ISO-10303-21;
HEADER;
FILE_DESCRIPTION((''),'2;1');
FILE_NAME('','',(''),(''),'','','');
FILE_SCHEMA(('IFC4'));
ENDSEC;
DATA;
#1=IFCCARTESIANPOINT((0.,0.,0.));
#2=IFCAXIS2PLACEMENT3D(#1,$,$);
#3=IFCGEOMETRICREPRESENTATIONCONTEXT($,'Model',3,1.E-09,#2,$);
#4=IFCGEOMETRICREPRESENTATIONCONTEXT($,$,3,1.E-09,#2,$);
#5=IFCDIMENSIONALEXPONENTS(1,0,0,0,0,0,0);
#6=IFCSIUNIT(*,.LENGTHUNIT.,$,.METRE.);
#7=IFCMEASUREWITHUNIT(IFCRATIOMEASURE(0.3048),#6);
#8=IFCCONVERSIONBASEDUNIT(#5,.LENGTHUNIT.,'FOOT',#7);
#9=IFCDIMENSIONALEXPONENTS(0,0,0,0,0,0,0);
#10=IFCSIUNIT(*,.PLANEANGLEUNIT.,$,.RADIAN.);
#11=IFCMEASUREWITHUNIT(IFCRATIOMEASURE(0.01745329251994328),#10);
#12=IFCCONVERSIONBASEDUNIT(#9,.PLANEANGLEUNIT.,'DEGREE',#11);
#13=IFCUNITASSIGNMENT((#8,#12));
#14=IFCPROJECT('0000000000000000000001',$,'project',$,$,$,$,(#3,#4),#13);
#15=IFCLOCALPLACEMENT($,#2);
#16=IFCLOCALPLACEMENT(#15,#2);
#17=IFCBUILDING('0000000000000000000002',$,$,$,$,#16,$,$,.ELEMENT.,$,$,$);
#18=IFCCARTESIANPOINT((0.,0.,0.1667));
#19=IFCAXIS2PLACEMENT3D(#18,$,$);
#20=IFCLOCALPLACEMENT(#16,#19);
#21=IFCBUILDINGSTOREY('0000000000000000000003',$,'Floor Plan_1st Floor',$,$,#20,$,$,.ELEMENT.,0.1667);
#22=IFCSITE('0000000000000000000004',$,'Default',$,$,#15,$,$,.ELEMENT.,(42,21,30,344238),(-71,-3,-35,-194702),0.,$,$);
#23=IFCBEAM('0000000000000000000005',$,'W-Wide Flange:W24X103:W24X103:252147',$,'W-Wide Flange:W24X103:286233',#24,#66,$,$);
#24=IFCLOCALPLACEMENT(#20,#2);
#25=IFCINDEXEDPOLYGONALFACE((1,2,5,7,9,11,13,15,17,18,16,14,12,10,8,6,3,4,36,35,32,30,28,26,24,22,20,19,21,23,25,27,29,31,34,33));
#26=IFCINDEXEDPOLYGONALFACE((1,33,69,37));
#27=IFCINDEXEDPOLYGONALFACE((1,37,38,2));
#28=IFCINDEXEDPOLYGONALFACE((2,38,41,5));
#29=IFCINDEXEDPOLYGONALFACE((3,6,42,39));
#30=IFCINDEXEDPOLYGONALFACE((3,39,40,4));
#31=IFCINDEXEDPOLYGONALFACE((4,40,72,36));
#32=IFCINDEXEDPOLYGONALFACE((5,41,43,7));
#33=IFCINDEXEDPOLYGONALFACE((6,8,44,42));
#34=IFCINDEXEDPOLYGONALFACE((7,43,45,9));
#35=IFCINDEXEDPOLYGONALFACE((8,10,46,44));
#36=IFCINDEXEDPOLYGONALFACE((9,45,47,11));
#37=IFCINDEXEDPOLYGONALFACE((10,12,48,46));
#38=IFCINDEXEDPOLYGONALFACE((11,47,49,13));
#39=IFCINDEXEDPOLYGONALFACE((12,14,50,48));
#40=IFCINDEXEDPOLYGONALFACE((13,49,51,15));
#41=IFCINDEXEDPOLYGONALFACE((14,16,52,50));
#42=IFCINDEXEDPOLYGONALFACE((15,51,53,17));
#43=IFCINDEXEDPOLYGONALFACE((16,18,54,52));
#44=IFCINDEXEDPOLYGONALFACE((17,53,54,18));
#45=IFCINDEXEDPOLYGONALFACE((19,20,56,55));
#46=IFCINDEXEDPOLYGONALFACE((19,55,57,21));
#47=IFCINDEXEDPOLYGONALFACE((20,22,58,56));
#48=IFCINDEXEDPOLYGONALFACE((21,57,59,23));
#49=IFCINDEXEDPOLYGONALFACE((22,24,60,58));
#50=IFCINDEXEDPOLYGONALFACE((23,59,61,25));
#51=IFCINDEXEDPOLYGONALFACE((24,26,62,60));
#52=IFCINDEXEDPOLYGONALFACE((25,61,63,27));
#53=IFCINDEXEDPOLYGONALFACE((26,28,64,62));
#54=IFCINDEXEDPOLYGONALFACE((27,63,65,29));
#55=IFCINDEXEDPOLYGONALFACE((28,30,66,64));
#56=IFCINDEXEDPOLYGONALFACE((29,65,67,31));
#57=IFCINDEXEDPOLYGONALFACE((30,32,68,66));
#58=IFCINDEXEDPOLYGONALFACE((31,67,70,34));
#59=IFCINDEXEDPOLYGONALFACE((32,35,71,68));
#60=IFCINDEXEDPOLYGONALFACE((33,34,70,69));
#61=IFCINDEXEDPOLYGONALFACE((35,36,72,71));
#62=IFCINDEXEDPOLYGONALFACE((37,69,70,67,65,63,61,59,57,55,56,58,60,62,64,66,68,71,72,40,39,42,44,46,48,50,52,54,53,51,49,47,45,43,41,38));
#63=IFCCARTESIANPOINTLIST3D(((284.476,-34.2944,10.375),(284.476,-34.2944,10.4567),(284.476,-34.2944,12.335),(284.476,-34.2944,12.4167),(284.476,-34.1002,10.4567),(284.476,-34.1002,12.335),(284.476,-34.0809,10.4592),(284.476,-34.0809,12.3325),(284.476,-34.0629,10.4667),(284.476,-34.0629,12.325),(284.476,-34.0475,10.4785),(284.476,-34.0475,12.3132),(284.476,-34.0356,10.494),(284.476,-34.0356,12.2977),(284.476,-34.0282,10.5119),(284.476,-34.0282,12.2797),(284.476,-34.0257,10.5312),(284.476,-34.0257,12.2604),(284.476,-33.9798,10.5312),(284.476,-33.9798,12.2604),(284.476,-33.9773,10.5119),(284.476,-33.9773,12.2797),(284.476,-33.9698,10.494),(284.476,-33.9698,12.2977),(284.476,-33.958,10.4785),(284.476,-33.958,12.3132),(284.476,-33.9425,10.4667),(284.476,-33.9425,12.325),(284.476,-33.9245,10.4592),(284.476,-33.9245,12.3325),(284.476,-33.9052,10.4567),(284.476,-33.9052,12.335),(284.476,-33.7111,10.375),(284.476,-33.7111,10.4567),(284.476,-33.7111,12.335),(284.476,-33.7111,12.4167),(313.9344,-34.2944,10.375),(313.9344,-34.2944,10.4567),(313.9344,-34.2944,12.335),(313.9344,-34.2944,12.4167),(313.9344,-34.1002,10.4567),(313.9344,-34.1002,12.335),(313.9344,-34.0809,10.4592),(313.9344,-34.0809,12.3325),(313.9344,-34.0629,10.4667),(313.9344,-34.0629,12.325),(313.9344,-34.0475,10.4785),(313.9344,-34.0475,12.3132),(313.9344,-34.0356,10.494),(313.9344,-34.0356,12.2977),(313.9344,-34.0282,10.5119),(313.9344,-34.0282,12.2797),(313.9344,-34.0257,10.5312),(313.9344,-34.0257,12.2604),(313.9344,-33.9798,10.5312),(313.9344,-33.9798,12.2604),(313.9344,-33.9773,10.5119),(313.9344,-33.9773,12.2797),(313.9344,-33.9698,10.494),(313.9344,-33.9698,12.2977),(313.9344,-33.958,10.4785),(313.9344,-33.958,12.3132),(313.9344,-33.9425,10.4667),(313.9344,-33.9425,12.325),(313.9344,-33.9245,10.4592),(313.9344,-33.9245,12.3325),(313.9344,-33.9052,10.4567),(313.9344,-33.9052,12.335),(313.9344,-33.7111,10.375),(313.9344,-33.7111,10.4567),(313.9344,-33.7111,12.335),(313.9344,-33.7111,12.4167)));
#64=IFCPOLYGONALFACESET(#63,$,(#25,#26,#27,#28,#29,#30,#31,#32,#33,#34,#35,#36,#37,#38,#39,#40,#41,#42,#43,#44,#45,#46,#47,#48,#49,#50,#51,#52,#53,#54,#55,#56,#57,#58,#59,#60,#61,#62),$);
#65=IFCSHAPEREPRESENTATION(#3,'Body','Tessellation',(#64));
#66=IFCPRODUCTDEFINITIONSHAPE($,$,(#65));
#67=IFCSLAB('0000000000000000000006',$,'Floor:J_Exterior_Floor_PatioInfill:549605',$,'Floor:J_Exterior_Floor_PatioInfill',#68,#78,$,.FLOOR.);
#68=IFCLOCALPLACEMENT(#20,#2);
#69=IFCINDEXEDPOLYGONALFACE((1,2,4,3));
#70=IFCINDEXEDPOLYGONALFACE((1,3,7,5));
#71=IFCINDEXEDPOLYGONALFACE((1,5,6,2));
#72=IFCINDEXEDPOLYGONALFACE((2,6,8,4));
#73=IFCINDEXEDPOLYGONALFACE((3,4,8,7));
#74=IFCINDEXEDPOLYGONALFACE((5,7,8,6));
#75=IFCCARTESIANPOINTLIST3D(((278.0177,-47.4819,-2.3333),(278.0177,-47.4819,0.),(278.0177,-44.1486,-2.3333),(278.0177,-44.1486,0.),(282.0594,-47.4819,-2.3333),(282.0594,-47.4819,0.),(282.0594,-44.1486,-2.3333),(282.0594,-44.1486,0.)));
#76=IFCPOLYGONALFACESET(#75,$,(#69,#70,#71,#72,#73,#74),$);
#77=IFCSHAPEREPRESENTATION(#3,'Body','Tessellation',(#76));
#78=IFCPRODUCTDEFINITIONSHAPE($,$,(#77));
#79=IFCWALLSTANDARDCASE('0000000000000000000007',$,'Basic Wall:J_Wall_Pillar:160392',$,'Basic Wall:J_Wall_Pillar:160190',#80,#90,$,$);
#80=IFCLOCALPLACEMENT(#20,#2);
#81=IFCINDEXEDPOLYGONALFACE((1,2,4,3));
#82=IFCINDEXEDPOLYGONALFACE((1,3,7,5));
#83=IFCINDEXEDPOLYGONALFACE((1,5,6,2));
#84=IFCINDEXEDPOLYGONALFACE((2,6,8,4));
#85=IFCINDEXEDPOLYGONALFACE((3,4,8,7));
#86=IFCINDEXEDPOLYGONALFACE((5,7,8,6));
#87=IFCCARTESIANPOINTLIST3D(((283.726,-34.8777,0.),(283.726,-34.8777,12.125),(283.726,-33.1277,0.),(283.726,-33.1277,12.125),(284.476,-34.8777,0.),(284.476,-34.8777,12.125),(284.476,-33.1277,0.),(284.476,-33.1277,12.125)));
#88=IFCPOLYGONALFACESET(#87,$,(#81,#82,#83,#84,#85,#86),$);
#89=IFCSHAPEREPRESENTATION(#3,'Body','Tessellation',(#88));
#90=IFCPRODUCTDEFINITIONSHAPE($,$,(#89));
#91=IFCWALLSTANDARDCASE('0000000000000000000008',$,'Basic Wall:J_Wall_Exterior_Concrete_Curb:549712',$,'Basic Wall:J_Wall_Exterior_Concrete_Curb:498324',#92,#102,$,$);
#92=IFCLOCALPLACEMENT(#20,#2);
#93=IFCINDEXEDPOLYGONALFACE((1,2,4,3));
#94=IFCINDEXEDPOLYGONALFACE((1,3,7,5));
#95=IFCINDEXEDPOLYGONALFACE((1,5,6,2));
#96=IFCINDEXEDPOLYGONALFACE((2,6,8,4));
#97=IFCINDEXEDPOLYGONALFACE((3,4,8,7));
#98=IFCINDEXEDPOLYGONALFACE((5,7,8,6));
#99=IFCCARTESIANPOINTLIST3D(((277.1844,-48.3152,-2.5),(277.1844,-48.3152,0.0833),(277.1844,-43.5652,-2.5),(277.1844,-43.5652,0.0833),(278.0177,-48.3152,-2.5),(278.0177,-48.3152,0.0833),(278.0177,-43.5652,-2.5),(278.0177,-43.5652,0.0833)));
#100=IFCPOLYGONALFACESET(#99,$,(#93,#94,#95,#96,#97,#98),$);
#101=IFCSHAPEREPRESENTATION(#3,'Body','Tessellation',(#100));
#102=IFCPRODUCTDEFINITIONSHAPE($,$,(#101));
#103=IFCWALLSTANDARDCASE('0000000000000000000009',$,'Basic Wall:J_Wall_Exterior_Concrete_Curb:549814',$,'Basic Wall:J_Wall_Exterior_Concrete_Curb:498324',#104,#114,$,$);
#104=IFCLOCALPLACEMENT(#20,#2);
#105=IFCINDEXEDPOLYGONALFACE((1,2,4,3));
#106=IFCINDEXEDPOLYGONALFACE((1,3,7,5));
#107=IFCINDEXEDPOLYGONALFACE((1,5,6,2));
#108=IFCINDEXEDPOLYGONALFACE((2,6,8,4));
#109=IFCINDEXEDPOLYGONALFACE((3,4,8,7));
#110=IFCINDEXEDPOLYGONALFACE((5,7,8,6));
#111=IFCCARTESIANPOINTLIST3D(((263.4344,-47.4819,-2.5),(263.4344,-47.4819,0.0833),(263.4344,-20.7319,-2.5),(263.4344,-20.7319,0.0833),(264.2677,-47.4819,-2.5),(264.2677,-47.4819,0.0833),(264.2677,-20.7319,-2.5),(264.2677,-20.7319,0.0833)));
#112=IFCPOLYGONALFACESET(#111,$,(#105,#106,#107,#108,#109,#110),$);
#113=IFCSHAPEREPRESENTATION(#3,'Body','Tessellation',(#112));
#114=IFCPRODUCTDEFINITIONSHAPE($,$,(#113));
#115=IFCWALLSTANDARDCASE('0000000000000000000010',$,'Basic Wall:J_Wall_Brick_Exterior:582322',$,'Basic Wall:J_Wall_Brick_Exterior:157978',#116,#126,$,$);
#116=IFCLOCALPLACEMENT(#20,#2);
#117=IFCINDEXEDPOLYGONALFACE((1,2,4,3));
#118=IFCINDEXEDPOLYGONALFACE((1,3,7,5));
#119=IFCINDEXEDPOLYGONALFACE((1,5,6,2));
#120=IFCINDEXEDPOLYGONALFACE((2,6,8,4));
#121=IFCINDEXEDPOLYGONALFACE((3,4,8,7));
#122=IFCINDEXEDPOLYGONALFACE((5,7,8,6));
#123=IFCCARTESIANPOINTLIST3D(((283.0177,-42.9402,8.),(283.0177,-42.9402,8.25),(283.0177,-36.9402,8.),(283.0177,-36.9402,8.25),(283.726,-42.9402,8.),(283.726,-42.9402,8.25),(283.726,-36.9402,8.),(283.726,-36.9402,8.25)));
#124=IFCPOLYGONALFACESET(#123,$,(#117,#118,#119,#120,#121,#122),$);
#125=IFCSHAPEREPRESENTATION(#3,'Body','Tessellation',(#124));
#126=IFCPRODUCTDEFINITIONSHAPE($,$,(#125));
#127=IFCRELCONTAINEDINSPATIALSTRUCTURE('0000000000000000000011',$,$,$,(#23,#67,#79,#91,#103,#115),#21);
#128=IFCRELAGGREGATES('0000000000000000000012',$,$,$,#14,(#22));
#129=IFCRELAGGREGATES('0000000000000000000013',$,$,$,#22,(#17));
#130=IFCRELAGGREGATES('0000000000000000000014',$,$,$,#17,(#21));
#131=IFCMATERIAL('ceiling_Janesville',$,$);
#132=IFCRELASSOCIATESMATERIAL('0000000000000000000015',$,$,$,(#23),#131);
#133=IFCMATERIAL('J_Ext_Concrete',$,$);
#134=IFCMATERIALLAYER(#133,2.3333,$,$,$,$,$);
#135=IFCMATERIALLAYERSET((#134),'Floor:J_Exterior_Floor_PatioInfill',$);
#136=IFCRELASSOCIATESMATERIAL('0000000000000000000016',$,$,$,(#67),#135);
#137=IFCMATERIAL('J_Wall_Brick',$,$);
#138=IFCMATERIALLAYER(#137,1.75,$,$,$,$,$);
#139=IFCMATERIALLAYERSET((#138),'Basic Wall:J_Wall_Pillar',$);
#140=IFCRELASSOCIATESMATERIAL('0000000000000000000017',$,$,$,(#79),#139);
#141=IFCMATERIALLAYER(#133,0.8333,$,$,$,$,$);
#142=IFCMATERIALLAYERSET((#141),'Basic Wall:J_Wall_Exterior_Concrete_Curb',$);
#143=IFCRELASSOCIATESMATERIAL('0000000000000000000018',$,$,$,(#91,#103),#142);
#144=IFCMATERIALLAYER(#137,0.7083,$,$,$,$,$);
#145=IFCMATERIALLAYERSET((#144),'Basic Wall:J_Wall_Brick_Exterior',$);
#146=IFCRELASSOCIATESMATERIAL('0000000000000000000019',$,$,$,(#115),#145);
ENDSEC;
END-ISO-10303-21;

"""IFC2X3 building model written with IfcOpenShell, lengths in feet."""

from ifc_helpers import new_model, entity, si_unit, converted_unit, frame, frame_2d, origin, place, context, project, spatial, polyline, circle_curve, parameter, trimmed, segment, composite_curve, rectangle, outline, extrude, clip, halfspace, material, layer, layer_set, layer_usage, element, save


model = new_model("IFC2X3")

# Units and contexts
model_context = context("Model", 3, precision=1e-09, world=origin())
context_of_model = context(None, 3, precision=1e-09, world=origin())
ifc_project = project(units=[converted_unit("LENGTHUNIT", "FOOT", entity("IfcRatioMeasure", 0.3048), si_unit("LENGTHUNIT", "METRE"), dimensions=[1, 0, 0, 0, 0, 0, 0]), converted_unit("PLANEANGLEUNIT", "DEGREE", entity("IfcRatioMeasure", 0.01745329251994328), si_unit("PLANEANGLEUNIT", "RADIAN"), dimensions=[0, 0, 0, 0, 0, 0, 0])], contexts=[model_context, context_of_model])

# Site, building, storey
site_placement = place(None, origin())
site = spatial("IfcSite", under=ifc_project, at=site_placement, Name="Default", CompositionType="ELEMENT", RefLatitude=(42, 21, 30, 344238), RefLongitude=(-71, -3, -35, -194702), RefElevation=0.0)
building_placement = place(site_placement, origin())
building = spatial("IfcBuilding", under=site, at=building_placement, CompositionType="ELEMENT")
storey_placement = place(building_placement, frame((0.0, 0.0, 0.1667)))
storey = spatial("IfcBuildingStorey", under=building, at=storey_placement, Name="Floor Plan_1st Floor", CompositionType="ELEMENT", Elevation=0.1667)

# Beam
ifc_material_1 = material(Name="ceiling_Janesville")
beam_1_placement = place(storey_placement, frame((284.4346, -34.0027, 12.4167), z_axis=(0.0, 0.0, 1.0), x_axis=(0.0, -1.0, 0.0)))
element("IfcBeam", 1, at=beam_1_placement, inside=storey, material=ifc_material_1, Name="W-Wide Flange:W24X103:W24X103:252147", ObjectType="W-Wide Flange:W24X103:286233", context=model_context, shape_type="SweptSolid", body=[
    extrude(outline(composite_curve([segment(polyline([(-0.2917, -0.9392), (-0.2917, -1.0208)]), True, "CONTINUOUS"), segment(polyline([(-0.2917, -1.0208), (0.2917, -1.0208)]), True, "CONTINUOUS"), segment(polyline([(0.2917, -1.0208), (0.2917, -0.9392)]), True, "CONTINUOUS"), segment(polyline([(0.2917, -0.9392), (0.0975, -0.9392)]), True, "CONTINUOUS"), segment(trimmed(circle_curve(frame_2d((0.0975, -0.8646), x_axis=(1.0, 0.0)), 0.0746), [parameter(180.0)], [parameter(270.0)], True, "PARAMETER"), False, "CONTINUOUS"), segment(polyline([(0.0229, -0.8646), (0.0229, 0.8646)]), True, "CONTINUOUS"), segment(trimmed(circle_curve(frame_2d((0.0975, 0.8646), x_axis=(1.0, 0.0)), 0.0746), [parameter(90.0)], [parameter(180.0)], True, "PARAMETER"), False, "CONTINUOUS"), segment(polyline([(0.0975, 0.9392), (0.2917, 0.9392)]), True, "CONTINUOUS"), segment(polyline([(0.2917, 0.9392), (0.2917, 1.0208)]), True, "CONTINUOUS"), segment(polyline([(0.2917, 1.0208), (-0.2917, 1.0208)]), True, "CONTINUOUS"), segment(polyline([(-0.2917, 1.0208), (-0.2917, 0.9392)]), True, "CONTINUOUS"), segment(polyline([(-0.2917, 0.9392), (-0.0975, 0.9392)]), True, "CONTINUOUS"), segment(trimmed(circle_curve(frame_2d((-0.0975, 0.8646), x_axis=(1.0, 0.0)), 0.0746), [parameter(360.0)], [parameter(90.0)], True, "PARAMETER"), False, "CONTINUOUS"), segment(polyline([(-0.0229, 0.8646), (-0.0229, -0.8646)]), True, "CONTINUOUS"), segment(trimmed(circle_curve(frame_2d((-0.0975, -0.8646), x_axis=(1.0, 0.0)), 0.0746), [parameter(270.0)], [parameter(360.0)], True, "PARAMETER"), False, "CONTINUOUS"), segment(polyline([(-0.0975, -0.9392), (-0.2917, -0.9392)]), True, "CONTINUOUS")], self_intersect=False)), frame((0.0, 0.0414, -1.0208), z_axis=(0.0, -1.0, 0.0), x_axis=(1.0, 0.0, 0.0)), (0.0, 0.0, -1.0), 29.4583),
])

# Slab
ifc_material_2 = material(Name="J_Ext_Concrete")
ifc_layer_1 = layer(ifc_material_2, 2.3333)
ifc_layer_set_1 = layer_set([ifc_layer_1], Name="Floor:J_Exterior_Floor_PatioInfill")
ifc_layer_usage_1 = layer_usage(ifc_layer_set_1, "AXIS3", "POSITIVE", 0.0)
slab_placement = place(storey_placement, frame((278.0177, -47.4819, -2.3333)))
element("IfcSlab", 2, at=slab_placement, inside=storey, material=ifc_layer_usage_1, Name="Floor:J_Exterior_Floor_PatioInfill:549605", ObjectType="Floor:J_Exterior_Floor_PatioInfill", PredefinedType="FLOOR", context=model_context, shape_type="SweptSolid", body=[
    extrude(rectangle(XDim=3.3333, YDim=4.0417, at=frame_2d((0.0, 0.0), x_axis=(0.0, -1.0))), frame((2.0208, 1.6667, 2.3333), z_axis=(0.0, 0.0, -1.0), x_axis=(-1.0, 0.0, 0.0)), (0.0, 0.0, 1.0), 2.3333),
])

# Walls
ifc_material_3 = material(Name="J_Wall_Brick")
ifc_layer_2 = layer(ifc_material_3, 1.75)
ifc_layer_set_2 = layer_set([ifc_layer_2], Name="Basic Wall:J_Wall_Pillar")
ifc_layer_usage_2 = layer_usage(ifc_layer_set_2, "AXIS2", "NEGATIVE", 0.875)
wall_1_placement = place(storey_placement, frame((283.726, -34.0027, 0.0)))
element("IfcWallStandardCase", 3, at=wall_1_placement, inside=storey, material=ifc_layer_usage_2, Name="Basic Wall:J_Wall_Pillar:160392", ObjectType="Basic Wall:J_Wall_Pillar:160190", context=model_context, shape_type="Clipping", body=[
    clip(extrude(rectangle(XDim=0.75, YDim=1.75, at=frame_2d((0.375, 0.0), x_axis=(-1.0, 0.0))), origin(), (0.0, 0.0, 1.0), 12.125), halfspace(origin(), True)),
])
ifc_layer_3 = layer(ifc_material_2, 0.8333)
ifc_layer_set_3 = layer_set([ifc_layer_3], Name="Basic Wall:J_Wall_Exterior_Concrete_Curb")
ifc_layer_usage_3 = layer_usage(ifc_layer_set_3, "AXIS2", "POSITIVE", -0.4167)
wall_2_placement = place(storey_placement, frame((277.601, -43.5652, -2.5), z_axis=(0.0, 0.0, 1.0), x_axis=(0.0, -1.0, 0.0)))
element("IfcWallStandardCase", 4, at=wall_2_placement, inside=storey, material=ifc_layer_usage_3, Name="Basic Wall:J_Wall_Exterior_Concrete_Curb:549712", ObjectType="Basic Wall:J_Wall_Exterior_Concrete_Curb:498324", context=model_context, shape_type="SweptSolid", body=[
    extrude(rectangle(XDim=4.75, YDim=0.8333, at=frame_2d((2.375, 0.0), x_axis=(-1.0, 0.0))), origin(), (0.0, 0.0, 1.0), 2.5833),
])
ifc_layer_usage_4 = layer_usage(ifc_layer_set_3, "AXIS2", "POSITIVE", -0.4167)
wall_3_placement = place(storey_placement, frame((263.851, -47.4819, -2.5), z_axis=(0.0, 0.0, 1.0), x_axis=(0.0, 1.0, 0.0)))
element("IfcWallStandardCase", 5, at=wall_3_placement, inside=storey, material=ifc_layer_usage_4, Name="Basic Wall:J_Wall_Exterior_Concrete_Curb:549814", ObjectType="Basic Wall:J_Wall_Exterior_Concrete_Curb:498324", context=model_context, shape_type="SweptSolid", body=[
    extrude(rectangle(XDim=26.75, YDim=0.8333, at=frame_2d((13.375, 0.0), x_axis=(-1.0, 0.0))), origin(), (0.0, 0.0, 1.0), 2.5833),
])

# Wall, opening
ifc_layer_4 = layer(ifc_material_3, 0.7083)
ifc_layer_set_4 = layer_set([ifc_layer_4], Name="Basic Wall:J_Wall_Brick_Exterior")
ifc_layer_usage_5 = layer_usage(ifc_layer_set_4, "AXIS2", "NEGATIVE", 0.3542)
wall_4_placement = place(storey_placement, frame((283.3719, -36.9402, 0.0), z_axis=(0.0, 0.0, 1.0), x_axis=(0.0, -1.0, 0.0)))
wall_4 = element("IfcWallStandardCase", 6, at=wall_4_placement, inside=storey, material=ifc_layer_usage_5, Name="Basic Wall:J_Wall_Brick_Exterior:582322", ObjectType="Basic Wall:J_Wall_Brick_Exterior:157978", context=model_context, shape_type="SweptSolid", body=[
    extrude(rectangle(XDim=6.0, YDim=0.7083, at=frame_2d((3.0, 0.0), x_axis=(-1.0, 0.0))), origin(), (0.0, 0.0, 1.0), 8.25),
])
opening_placement = place(wall_4_placement, frame((6.0, 0.3542, 0.0)))
element("IfcOpeningElement", 7, at=opening_placement, cuts=wall_4, ObjectType="Opening", context=model_context, shape_type="SweptSolid", body=[
    extrude(rectangle(XDim=8.0, YDim=6.0, at=frame_2d((4.0, 3.0), x_axis=(1.0, 0.0))), frame((0.0, 0.0, 0.0), z_axis=(0.0, -1.0, 0.0), x_axis=(0.0, 0.0, 1.0)), (0.0, 0.0, 1.0), 0.7083),
])

save(model, "model.ifc")
